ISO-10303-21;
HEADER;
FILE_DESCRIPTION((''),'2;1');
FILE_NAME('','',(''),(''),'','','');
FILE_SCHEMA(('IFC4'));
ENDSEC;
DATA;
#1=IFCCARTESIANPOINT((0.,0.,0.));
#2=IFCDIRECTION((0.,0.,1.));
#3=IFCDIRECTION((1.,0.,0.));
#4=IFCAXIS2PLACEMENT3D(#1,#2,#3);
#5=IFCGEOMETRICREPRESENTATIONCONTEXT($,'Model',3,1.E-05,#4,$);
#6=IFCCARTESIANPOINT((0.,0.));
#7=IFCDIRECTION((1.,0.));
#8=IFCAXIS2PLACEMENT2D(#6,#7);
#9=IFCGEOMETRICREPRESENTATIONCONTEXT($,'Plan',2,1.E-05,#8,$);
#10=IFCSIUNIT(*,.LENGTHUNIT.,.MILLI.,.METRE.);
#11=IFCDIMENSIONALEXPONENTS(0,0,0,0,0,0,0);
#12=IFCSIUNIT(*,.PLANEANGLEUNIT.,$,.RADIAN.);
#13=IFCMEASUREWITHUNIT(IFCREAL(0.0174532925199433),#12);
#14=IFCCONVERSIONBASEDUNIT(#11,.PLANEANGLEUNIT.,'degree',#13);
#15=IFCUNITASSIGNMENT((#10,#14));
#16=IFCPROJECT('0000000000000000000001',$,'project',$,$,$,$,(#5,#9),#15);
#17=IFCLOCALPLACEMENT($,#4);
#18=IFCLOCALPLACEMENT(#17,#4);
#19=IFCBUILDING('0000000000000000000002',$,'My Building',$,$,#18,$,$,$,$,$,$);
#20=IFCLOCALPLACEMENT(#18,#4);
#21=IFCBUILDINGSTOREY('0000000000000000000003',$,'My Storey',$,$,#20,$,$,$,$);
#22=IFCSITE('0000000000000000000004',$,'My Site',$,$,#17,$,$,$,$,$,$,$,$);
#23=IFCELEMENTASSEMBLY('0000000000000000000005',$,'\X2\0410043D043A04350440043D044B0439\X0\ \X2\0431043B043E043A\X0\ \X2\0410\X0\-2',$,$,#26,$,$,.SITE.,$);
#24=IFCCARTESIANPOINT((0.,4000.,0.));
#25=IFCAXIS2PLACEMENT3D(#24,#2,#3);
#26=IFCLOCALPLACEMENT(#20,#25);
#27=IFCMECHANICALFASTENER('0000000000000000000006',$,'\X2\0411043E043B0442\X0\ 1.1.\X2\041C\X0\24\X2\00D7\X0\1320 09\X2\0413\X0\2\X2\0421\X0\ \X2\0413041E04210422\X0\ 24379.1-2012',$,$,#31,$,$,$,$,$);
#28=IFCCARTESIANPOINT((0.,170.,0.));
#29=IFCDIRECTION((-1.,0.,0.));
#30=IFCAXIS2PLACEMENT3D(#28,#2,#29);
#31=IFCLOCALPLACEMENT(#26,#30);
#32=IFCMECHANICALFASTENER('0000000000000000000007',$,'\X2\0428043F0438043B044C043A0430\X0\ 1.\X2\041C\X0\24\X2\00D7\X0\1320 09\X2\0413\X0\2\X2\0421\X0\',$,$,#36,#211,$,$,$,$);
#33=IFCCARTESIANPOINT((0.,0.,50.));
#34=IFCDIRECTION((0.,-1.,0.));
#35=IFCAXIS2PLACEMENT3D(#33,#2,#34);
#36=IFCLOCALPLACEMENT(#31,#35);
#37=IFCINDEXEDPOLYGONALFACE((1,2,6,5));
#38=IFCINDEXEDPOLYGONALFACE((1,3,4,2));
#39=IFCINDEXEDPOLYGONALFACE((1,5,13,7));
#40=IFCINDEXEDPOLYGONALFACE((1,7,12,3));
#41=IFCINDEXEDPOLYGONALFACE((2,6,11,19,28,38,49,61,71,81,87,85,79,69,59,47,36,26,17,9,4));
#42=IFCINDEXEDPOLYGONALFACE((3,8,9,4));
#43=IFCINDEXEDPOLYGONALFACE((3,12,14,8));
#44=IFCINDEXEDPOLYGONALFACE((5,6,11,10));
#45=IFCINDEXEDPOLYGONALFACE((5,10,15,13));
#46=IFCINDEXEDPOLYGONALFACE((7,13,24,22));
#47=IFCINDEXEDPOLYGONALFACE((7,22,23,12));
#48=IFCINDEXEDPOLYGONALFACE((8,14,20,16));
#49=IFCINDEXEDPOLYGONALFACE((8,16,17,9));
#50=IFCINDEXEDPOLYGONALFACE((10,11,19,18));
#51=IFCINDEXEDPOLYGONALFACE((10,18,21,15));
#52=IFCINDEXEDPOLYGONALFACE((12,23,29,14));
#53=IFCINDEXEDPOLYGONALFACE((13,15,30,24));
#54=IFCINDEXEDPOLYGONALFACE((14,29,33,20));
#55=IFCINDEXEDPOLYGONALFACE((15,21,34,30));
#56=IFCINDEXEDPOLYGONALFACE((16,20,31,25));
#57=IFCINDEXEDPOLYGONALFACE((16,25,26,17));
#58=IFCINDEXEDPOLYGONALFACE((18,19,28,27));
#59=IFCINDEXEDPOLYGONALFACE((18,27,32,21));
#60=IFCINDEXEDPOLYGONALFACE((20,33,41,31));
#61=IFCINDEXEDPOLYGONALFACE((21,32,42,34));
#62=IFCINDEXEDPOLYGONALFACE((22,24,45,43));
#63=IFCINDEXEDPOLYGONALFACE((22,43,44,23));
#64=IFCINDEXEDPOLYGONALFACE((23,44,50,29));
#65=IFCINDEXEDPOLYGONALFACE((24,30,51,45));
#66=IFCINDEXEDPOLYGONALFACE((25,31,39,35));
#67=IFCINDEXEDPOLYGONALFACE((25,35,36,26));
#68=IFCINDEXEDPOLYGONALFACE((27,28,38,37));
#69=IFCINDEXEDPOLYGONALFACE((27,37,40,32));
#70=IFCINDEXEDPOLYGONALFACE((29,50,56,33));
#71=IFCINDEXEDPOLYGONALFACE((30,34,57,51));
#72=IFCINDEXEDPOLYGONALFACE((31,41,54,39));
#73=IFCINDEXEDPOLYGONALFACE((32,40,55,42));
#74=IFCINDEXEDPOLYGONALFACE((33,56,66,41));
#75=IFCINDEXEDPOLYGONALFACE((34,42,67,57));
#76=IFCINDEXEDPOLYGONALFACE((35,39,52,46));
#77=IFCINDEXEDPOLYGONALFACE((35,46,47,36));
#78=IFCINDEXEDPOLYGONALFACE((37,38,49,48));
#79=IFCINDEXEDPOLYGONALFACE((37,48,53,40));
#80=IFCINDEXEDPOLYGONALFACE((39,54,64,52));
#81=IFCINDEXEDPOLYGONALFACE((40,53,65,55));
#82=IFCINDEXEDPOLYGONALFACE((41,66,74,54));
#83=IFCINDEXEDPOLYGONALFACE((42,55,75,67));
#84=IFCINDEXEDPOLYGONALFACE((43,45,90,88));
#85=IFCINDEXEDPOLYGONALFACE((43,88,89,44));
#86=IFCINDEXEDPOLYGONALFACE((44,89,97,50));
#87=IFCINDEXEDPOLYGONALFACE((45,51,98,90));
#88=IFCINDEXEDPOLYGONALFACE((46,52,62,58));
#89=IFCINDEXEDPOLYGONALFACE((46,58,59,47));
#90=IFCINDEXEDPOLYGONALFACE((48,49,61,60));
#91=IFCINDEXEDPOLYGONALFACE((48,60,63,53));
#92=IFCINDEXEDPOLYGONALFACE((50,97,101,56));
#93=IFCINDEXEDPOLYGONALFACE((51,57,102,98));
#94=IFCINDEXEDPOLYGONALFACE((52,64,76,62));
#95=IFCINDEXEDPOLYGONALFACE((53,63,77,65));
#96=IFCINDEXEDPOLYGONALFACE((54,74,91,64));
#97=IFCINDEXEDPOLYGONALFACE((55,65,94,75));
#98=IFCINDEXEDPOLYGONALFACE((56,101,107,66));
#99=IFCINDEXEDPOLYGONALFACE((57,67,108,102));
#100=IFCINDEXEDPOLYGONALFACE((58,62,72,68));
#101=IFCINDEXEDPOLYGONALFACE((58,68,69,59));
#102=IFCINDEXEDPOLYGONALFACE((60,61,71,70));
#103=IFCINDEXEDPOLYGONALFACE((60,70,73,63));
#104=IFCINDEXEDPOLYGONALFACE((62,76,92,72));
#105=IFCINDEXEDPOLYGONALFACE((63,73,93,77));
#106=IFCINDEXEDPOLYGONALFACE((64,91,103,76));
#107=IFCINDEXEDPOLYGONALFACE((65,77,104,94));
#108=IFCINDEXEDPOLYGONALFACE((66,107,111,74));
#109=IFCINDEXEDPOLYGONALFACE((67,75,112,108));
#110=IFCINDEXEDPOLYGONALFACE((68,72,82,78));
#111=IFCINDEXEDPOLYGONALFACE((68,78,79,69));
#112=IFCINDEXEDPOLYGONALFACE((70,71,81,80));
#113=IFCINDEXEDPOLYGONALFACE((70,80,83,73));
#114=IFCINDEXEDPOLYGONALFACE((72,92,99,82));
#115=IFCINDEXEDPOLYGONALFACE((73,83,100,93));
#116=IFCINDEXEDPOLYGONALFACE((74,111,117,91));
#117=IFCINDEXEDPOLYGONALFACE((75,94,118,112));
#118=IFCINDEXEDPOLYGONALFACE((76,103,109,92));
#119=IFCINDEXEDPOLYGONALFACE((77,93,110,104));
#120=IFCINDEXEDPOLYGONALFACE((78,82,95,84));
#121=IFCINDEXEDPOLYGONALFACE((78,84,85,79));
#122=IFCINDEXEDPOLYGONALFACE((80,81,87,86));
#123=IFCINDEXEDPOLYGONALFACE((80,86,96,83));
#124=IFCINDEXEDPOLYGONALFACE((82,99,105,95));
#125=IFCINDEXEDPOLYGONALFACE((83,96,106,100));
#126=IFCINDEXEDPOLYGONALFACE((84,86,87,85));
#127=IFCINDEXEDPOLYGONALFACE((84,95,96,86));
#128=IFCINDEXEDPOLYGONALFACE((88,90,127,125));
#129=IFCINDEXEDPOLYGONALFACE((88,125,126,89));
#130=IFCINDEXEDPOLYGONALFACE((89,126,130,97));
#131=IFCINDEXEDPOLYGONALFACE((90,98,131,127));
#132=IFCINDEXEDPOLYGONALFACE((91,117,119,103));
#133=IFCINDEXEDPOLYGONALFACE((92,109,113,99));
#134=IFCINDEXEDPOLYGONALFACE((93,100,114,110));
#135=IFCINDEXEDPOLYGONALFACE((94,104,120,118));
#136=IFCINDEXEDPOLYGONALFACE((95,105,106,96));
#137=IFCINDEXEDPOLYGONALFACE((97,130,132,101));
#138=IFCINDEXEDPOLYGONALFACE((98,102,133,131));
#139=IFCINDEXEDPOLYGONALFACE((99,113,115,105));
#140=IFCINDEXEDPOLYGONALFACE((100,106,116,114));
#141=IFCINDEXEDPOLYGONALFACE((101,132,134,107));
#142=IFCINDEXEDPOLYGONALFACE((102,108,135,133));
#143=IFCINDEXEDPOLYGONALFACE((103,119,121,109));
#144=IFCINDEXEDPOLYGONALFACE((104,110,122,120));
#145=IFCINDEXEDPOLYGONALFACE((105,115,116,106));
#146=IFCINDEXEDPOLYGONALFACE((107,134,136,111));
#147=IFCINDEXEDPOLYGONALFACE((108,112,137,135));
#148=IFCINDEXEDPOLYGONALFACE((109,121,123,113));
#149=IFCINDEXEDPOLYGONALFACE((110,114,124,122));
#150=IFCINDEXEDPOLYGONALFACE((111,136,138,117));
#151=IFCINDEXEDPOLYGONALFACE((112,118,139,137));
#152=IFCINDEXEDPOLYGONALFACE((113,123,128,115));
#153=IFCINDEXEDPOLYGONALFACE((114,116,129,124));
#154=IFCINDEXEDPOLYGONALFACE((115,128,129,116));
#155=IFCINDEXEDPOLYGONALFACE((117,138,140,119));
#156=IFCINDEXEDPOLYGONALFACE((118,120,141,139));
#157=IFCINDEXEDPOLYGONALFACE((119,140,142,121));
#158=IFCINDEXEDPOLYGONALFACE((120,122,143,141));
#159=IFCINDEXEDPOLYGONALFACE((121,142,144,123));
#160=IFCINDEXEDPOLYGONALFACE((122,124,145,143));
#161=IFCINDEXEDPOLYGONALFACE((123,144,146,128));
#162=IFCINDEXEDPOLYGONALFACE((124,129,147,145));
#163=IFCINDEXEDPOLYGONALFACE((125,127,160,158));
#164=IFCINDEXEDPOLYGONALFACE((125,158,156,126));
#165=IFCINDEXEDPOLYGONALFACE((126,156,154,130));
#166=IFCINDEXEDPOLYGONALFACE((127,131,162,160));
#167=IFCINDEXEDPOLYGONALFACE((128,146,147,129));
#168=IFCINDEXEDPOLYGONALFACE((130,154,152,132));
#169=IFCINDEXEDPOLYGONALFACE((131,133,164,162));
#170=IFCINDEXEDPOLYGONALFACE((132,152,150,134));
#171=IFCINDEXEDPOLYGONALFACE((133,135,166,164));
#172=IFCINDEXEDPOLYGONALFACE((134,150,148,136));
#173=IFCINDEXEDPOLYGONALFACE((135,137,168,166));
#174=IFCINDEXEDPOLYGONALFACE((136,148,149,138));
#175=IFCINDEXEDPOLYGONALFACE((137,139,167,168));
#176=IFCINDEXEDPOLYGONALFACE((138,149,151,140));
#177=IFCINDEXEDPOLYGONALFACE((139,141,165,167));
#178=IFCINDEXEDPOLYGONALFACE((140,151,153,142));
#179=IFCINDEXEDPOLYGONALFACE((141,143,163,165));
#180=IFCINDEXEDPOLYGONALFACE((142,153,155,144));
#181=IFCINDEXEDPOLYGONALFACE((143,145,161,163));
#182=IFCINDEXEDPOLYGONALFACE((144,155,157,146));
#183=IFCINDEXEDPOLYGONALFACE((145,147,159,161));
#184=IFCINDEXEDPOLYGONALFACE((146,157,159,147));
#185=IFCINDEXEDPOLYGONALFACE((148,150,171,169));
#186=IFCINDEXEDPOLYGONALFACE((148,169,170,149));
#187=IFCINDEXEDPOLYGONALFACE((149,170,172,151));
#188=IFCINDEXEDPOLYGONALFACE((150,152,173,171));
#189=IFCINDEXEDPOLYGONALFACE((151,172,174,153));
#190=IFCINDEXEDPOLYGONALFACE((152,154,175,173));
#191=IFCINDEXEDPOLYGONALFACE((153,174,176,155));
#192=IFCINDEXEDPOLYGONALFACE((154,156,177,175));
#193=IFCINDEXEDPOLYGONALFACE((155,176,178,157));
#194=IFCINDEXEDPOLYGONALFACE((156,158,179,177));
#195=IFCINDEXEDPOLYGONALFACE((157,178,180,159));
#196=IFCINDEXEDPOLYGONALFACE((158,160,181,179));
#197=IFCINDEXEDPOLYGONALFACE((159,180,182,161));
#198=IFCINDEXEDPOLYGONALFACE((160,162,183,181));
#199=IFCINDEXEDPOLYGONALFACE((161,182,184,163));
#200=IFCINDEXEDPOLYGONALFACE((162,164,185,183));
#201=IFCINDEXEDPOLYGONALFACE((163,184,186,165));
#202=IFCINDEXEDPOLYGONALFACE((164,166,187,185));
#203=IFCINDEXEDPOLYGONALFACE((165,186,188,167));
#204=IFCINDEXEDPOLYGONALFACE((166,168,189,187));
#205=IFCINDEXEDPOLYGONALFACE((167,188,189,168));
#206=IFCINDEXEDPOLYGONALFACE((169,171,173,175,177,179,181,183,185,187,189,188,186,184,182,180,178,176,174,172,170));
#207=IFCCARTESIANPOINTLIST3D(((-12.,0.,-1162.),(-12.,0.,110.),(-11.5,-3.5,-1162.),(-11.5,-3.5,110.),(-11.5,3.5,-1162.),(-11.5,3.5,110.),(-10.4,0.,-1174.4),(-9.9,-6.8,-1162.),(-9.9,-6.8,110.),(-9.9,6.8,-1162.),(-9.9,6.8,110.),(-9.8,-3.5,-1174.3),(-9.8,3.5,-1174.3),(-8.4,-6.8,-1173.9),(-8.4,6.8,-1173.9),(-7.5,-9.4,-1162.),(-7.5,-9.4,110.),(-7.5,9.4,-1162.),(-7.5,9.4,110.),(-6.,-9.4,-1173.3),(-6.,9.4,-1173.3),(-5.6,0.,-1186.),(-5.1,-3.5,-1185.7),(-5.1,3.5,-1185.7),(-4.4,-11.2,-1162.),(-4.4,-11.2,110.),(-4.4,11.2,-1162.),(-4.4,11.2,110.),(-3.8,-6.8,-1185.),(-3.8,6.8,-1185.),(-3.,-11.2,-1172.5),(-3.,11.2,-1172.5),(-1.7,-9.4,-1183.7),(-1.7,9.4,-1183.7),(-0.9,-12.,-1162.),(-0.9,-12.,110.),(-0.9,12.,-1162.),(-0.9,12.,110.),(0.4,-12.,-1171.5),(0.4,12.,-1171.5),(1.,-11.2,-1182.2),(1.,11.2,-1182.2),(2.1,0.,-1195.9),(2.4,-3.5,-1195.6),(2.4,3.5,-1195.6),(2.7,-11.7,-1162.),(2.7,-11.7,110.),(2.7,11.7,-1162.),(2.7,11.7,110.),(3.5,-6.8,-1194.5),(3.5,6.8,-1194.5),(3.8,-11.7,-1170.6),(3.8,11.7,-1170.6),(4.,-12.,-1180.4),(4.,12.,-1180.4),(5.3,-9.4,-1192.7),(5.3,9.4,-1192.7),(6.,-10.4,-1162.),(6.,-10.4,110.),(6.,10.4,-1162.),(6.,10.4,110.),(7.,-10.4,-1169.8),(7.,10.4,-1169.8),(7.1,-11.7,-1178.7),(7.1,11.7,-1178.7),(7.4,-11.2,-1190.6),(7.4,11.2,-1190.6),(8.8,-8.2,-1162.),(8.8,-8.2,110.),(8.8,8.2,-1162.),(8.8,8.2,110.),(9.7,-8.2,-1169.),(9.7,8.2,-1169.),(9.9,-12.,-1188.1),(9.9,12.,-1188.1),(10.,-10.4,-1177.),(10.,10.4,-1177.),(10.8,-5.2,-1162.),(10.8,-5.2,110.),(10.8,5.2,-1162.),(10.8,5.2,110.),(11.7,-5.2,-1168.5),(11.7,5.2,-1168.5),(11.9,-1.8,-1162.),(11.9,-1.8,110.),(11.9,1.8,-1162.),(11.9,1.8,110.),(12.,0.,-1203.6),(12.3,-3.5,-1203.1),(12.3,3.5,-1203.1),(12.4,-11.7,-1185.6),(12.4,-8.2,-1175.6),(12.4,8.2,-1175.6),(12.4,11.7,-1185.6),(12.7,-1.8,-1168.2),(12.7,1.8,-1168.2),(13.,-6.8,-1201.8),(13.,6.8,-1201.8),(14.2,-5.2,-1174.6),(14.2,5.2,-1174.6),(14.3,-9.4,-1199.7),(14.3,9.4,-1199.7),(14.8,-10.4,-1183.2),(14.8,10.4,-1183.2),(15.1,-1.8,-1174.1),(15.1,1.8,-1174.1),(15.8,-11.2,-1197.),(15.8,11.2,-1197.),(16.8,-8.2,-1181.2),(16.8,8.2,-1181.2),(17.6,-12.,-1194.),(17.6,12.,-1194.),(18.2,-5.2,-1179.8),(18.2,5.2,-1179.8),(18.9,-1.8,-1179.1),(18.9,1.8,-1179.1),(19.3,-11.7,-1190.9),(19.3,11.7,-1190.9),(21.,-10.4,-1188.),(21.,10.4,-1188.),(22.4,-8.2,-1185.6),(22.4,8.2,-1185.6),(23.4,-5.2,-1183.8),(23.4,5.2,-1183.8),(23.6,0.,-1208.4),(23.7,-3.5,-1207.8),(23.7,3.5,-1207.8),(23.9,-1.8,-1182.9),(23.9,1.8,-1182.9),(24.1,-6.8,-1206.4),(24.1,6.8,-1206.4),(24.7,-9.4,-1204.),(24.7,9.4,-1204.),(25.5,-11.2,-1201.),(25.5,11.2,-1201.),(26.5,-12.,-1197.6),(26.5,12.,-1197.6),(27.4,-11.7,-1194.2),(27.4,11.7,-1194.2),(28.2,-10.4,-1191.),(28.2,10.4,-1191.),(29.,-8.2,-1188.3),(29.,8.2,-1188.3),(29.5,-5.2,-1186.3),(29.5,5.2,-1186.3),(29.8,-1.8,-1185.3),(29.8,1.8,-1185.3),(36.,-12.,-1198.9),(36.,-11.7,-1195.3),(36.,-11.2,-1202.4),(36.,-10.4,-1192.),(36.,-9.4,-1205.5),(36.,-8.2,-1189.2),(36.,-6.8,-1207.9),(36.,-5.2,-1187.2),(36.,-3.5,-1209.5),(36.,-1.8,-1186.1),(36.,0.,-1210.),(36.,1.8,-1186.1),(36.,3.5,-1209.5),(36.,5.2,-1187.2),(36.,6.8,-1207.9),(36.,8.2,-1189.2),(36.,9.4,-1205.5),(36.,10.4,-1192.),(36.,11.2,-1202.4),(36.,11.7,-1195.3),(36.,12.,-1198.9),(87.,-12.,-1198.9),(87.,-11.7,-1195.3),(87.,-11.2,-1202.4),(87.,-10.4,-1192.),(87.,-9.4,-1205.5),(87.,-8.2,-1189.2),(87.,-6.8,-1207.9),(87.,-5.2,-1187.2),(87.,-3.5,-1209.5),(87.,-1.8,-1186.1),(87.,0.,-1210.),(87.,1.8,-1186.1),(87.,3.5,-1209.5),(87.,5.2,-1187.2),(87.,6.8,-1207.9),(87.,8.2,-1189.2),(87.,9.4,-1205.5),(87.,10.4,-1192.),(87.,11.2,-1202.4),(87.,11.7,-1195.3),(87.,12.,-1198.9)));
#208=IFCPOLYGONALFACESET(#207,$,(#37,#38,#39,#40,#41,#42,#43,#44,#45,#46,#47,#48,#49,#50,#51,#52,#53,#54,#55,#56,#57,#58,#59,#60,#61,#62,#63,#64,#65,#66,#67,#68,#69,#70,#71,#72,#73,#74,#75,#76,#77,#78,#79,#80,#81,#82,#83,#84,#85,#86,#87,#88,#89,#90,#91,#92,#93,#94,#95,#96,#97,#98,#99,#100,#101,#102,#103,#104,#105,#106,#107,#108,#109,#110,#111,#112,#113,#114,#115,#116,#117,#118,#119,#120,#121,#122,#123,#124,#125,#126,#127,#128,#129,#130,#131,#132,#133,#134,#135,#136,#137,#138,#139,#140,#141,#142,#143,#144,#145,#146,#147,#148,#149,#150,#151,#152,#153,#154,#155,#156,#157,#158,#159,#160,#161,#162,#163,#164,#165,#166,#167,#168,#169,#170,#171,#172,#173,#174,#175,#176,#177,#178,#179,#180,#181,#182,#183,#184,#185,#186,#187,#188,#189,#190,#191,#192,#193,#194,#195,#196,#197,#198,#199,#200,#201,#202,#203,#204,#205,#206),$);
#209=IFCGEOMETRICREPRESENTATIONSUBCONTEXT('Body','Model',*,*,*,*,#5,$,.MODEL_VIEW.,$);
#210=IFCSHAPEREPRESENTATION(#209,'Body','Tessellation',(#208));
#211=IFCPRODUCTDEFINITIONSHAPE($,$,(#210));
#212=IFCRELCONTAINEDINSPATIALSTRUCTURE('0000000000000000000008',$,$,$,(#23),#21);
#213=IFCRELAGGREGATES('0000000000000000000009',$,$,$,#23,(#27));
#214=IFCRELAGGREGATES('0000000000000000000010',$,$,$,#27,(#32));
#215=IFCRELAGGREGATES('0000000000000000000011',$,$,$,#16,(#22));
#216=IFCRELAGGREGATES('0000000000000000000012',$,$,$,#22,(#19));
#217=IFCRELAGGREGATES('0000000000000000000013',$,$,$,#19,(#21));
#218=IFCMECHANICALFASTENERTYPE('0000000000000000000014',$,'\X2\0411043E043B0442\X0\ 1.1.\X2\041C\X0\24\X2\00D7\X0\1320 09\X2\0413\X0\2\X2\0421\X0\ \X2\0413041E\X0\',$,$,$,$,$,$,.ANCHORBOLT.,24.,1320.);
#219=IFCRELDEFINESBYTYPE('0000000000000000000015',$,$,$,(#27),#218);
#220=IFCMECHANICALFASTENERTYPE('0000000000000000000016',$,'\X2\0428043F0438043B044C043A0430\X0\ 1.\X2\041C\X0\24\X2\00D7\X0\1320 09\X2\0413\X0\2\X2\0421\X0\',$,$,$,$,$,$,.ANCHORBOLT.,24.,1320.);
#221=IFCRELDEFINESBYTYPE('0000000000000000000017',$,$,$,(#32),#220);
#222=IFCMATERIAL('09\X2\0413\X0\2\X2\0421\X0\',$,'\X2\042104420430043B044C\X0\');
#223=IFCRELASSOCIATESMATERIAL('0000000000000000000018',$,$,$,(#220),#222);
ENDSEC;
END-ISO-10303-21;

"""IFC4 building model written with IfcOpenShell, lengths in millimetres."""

from ifc_helpers import new_model, entity, si_unit, converted_unit, frame, origin_with_axes, origin_2d_with_axis, place, context, subcontext, project, spatial, source, transform, mapped, material, type_object, type_shapes, element, aggregate, save


model = new_model("IFC4")

# Units and contexts
model_context = context("Model", 3, precision=1e-05, world=origin_with_axes())
plan_context = context("Plan", 2, precision=1e-05, world=origin_2d_with_axis())
body_context = subcontext(model_context, "Body", "Model", "MODEL_VIEW")
ifc_project = project(units=[si_unit("LENGTHUNIT", "METRE", prefix="MILLI"), converted_unit("PLANEANGLEUNIT", "degree", entity("IfcReal", 0.0174532925199433), si_unit("PLANEANGLEUNIT", "RADIAN"), dimensions=[0, 0, 0, 0, 0, 0, 0])], contexts=[model_context, plan_context])

# Site, building, storey
site_placement = place(None, origin_with_axes())
site = spatial("IfcSite", under=ifc_project, at=site_placement, Name="My Site")
building_placement = place(site_placement, origin_with_axes())
building = spatial("IfcBuilding", under=site, at=building_placement, Name="My Building")
storey_placement = place(building_placement, origin_with_axes())
storey = spatial("IfcBuildingStorey", under=building, at=storey_placement, Name="My Storey")

# Shared definitions
placement_1 = place(storey_placement, frame((0.0, 4000.0, 0.0), z_axis=(0.0, 0.0, 1.0), x_axis=(1.0, 0.0, 0.0)))

# Element assembly, mechanical fasteners
ifc_material_1 = material(Name="09Г2С", Category="Сталь")
mechanical_fastener_type_1 = type_object("IfcMechanicalFastenerType", Name="Шпилька 1.М24×1320 09Г2С", NominalDiameter=24.0, NominalLength=1320.0, PredefinedType="ANCHORBOLT", material=ifc_material_1)
shared_shape_1 = source(frame((0.0, 0.0, 110.0), z_axis=(0.0, 0.0, 1.0), x_axis=(1.0, 0.0, 0.0)), body_context, "Body", "AdvancedSweptSolid", [
    entity("IfcSweptDiskSolid", entity("IfcIndexedPolyCurve", entity("IfcCartesianPointList3D", [[0.0, 0.0, 0.0], [0.0, 0.0, -1272.0], [10.5, 0.0, -1297.5], [36.0, 0.0, -1308.0], [87.0, 0.0, -1308.0]]), [entity("IfcLineIndex", [1, 2]), entity("IfcArcIndex", [2, 3, 4]), entity("IfcLineIndex", [4, 5])]), 12.0),
])
type_shapes(mechanical_fastener_type_1, [shared_shape_1])
mechanical_fastener_type_2 = type_object("IfcMechanicalFastenerType", Name="Болт 1.1.М24×1320 09Г2С ГО", NominalDiameter=24.0, NominalLength=1320.0, PredefinedType="ANCHORBOLT")
assembly_1 = element("IfcElementAssembly", 1, at=placement_1, inside=storey, Name="Анкерный блок А-2", AssemblyPlace="SITE")
mechanical_fastener_1_placement = place(placement_1, frame((0.0, 170.0, 0.0), z_axis=(0.0, 0.0, 1.0), x_axis=(-1.0, 0.0, 0.0)))
mechanical_fastener_1 = element("IfcMechanicalFastener", 2, at=mechanical_fastener_1_placement, type_object=mechanical_fastener_type_2, Name="Болт 1.1.М24×1320 09Г2С ГОСТ 24379.1-2012")
aggregate(assembly_1, [mechanical_fastener_1])
mechanical_fastener_2_placement = place(mechanical_fastener_1_placement, frame((0.0, 0.0, 50.0), z_axis=(0.0, 0.0, 1.0), x_axis=(0.0, -1.0, 0.0)))
mechanical_fastener_2 = element("IfcMechanicalFastener", 3, at=mechanical_fastener_2_placement, type_object=mechanical_fastener_type_1, Name="Шпилька 1.М24×1320 09Г2С", context=body_context, shape_type="MappedRepresentation", body=[
    mapped(shared_shape_1, transform((0.0, 0.0, 0.0), x_axis=(1.0, 0.0, 0.0), y_axis=(0.0, 1.0, 0.0), z_axis=(0.0, 0.0, 1.0), scale=1.0)),
])

aggregate(mechanical_fastener_1, [mechanical_fastener_2])

save(model, "model.ifc")
